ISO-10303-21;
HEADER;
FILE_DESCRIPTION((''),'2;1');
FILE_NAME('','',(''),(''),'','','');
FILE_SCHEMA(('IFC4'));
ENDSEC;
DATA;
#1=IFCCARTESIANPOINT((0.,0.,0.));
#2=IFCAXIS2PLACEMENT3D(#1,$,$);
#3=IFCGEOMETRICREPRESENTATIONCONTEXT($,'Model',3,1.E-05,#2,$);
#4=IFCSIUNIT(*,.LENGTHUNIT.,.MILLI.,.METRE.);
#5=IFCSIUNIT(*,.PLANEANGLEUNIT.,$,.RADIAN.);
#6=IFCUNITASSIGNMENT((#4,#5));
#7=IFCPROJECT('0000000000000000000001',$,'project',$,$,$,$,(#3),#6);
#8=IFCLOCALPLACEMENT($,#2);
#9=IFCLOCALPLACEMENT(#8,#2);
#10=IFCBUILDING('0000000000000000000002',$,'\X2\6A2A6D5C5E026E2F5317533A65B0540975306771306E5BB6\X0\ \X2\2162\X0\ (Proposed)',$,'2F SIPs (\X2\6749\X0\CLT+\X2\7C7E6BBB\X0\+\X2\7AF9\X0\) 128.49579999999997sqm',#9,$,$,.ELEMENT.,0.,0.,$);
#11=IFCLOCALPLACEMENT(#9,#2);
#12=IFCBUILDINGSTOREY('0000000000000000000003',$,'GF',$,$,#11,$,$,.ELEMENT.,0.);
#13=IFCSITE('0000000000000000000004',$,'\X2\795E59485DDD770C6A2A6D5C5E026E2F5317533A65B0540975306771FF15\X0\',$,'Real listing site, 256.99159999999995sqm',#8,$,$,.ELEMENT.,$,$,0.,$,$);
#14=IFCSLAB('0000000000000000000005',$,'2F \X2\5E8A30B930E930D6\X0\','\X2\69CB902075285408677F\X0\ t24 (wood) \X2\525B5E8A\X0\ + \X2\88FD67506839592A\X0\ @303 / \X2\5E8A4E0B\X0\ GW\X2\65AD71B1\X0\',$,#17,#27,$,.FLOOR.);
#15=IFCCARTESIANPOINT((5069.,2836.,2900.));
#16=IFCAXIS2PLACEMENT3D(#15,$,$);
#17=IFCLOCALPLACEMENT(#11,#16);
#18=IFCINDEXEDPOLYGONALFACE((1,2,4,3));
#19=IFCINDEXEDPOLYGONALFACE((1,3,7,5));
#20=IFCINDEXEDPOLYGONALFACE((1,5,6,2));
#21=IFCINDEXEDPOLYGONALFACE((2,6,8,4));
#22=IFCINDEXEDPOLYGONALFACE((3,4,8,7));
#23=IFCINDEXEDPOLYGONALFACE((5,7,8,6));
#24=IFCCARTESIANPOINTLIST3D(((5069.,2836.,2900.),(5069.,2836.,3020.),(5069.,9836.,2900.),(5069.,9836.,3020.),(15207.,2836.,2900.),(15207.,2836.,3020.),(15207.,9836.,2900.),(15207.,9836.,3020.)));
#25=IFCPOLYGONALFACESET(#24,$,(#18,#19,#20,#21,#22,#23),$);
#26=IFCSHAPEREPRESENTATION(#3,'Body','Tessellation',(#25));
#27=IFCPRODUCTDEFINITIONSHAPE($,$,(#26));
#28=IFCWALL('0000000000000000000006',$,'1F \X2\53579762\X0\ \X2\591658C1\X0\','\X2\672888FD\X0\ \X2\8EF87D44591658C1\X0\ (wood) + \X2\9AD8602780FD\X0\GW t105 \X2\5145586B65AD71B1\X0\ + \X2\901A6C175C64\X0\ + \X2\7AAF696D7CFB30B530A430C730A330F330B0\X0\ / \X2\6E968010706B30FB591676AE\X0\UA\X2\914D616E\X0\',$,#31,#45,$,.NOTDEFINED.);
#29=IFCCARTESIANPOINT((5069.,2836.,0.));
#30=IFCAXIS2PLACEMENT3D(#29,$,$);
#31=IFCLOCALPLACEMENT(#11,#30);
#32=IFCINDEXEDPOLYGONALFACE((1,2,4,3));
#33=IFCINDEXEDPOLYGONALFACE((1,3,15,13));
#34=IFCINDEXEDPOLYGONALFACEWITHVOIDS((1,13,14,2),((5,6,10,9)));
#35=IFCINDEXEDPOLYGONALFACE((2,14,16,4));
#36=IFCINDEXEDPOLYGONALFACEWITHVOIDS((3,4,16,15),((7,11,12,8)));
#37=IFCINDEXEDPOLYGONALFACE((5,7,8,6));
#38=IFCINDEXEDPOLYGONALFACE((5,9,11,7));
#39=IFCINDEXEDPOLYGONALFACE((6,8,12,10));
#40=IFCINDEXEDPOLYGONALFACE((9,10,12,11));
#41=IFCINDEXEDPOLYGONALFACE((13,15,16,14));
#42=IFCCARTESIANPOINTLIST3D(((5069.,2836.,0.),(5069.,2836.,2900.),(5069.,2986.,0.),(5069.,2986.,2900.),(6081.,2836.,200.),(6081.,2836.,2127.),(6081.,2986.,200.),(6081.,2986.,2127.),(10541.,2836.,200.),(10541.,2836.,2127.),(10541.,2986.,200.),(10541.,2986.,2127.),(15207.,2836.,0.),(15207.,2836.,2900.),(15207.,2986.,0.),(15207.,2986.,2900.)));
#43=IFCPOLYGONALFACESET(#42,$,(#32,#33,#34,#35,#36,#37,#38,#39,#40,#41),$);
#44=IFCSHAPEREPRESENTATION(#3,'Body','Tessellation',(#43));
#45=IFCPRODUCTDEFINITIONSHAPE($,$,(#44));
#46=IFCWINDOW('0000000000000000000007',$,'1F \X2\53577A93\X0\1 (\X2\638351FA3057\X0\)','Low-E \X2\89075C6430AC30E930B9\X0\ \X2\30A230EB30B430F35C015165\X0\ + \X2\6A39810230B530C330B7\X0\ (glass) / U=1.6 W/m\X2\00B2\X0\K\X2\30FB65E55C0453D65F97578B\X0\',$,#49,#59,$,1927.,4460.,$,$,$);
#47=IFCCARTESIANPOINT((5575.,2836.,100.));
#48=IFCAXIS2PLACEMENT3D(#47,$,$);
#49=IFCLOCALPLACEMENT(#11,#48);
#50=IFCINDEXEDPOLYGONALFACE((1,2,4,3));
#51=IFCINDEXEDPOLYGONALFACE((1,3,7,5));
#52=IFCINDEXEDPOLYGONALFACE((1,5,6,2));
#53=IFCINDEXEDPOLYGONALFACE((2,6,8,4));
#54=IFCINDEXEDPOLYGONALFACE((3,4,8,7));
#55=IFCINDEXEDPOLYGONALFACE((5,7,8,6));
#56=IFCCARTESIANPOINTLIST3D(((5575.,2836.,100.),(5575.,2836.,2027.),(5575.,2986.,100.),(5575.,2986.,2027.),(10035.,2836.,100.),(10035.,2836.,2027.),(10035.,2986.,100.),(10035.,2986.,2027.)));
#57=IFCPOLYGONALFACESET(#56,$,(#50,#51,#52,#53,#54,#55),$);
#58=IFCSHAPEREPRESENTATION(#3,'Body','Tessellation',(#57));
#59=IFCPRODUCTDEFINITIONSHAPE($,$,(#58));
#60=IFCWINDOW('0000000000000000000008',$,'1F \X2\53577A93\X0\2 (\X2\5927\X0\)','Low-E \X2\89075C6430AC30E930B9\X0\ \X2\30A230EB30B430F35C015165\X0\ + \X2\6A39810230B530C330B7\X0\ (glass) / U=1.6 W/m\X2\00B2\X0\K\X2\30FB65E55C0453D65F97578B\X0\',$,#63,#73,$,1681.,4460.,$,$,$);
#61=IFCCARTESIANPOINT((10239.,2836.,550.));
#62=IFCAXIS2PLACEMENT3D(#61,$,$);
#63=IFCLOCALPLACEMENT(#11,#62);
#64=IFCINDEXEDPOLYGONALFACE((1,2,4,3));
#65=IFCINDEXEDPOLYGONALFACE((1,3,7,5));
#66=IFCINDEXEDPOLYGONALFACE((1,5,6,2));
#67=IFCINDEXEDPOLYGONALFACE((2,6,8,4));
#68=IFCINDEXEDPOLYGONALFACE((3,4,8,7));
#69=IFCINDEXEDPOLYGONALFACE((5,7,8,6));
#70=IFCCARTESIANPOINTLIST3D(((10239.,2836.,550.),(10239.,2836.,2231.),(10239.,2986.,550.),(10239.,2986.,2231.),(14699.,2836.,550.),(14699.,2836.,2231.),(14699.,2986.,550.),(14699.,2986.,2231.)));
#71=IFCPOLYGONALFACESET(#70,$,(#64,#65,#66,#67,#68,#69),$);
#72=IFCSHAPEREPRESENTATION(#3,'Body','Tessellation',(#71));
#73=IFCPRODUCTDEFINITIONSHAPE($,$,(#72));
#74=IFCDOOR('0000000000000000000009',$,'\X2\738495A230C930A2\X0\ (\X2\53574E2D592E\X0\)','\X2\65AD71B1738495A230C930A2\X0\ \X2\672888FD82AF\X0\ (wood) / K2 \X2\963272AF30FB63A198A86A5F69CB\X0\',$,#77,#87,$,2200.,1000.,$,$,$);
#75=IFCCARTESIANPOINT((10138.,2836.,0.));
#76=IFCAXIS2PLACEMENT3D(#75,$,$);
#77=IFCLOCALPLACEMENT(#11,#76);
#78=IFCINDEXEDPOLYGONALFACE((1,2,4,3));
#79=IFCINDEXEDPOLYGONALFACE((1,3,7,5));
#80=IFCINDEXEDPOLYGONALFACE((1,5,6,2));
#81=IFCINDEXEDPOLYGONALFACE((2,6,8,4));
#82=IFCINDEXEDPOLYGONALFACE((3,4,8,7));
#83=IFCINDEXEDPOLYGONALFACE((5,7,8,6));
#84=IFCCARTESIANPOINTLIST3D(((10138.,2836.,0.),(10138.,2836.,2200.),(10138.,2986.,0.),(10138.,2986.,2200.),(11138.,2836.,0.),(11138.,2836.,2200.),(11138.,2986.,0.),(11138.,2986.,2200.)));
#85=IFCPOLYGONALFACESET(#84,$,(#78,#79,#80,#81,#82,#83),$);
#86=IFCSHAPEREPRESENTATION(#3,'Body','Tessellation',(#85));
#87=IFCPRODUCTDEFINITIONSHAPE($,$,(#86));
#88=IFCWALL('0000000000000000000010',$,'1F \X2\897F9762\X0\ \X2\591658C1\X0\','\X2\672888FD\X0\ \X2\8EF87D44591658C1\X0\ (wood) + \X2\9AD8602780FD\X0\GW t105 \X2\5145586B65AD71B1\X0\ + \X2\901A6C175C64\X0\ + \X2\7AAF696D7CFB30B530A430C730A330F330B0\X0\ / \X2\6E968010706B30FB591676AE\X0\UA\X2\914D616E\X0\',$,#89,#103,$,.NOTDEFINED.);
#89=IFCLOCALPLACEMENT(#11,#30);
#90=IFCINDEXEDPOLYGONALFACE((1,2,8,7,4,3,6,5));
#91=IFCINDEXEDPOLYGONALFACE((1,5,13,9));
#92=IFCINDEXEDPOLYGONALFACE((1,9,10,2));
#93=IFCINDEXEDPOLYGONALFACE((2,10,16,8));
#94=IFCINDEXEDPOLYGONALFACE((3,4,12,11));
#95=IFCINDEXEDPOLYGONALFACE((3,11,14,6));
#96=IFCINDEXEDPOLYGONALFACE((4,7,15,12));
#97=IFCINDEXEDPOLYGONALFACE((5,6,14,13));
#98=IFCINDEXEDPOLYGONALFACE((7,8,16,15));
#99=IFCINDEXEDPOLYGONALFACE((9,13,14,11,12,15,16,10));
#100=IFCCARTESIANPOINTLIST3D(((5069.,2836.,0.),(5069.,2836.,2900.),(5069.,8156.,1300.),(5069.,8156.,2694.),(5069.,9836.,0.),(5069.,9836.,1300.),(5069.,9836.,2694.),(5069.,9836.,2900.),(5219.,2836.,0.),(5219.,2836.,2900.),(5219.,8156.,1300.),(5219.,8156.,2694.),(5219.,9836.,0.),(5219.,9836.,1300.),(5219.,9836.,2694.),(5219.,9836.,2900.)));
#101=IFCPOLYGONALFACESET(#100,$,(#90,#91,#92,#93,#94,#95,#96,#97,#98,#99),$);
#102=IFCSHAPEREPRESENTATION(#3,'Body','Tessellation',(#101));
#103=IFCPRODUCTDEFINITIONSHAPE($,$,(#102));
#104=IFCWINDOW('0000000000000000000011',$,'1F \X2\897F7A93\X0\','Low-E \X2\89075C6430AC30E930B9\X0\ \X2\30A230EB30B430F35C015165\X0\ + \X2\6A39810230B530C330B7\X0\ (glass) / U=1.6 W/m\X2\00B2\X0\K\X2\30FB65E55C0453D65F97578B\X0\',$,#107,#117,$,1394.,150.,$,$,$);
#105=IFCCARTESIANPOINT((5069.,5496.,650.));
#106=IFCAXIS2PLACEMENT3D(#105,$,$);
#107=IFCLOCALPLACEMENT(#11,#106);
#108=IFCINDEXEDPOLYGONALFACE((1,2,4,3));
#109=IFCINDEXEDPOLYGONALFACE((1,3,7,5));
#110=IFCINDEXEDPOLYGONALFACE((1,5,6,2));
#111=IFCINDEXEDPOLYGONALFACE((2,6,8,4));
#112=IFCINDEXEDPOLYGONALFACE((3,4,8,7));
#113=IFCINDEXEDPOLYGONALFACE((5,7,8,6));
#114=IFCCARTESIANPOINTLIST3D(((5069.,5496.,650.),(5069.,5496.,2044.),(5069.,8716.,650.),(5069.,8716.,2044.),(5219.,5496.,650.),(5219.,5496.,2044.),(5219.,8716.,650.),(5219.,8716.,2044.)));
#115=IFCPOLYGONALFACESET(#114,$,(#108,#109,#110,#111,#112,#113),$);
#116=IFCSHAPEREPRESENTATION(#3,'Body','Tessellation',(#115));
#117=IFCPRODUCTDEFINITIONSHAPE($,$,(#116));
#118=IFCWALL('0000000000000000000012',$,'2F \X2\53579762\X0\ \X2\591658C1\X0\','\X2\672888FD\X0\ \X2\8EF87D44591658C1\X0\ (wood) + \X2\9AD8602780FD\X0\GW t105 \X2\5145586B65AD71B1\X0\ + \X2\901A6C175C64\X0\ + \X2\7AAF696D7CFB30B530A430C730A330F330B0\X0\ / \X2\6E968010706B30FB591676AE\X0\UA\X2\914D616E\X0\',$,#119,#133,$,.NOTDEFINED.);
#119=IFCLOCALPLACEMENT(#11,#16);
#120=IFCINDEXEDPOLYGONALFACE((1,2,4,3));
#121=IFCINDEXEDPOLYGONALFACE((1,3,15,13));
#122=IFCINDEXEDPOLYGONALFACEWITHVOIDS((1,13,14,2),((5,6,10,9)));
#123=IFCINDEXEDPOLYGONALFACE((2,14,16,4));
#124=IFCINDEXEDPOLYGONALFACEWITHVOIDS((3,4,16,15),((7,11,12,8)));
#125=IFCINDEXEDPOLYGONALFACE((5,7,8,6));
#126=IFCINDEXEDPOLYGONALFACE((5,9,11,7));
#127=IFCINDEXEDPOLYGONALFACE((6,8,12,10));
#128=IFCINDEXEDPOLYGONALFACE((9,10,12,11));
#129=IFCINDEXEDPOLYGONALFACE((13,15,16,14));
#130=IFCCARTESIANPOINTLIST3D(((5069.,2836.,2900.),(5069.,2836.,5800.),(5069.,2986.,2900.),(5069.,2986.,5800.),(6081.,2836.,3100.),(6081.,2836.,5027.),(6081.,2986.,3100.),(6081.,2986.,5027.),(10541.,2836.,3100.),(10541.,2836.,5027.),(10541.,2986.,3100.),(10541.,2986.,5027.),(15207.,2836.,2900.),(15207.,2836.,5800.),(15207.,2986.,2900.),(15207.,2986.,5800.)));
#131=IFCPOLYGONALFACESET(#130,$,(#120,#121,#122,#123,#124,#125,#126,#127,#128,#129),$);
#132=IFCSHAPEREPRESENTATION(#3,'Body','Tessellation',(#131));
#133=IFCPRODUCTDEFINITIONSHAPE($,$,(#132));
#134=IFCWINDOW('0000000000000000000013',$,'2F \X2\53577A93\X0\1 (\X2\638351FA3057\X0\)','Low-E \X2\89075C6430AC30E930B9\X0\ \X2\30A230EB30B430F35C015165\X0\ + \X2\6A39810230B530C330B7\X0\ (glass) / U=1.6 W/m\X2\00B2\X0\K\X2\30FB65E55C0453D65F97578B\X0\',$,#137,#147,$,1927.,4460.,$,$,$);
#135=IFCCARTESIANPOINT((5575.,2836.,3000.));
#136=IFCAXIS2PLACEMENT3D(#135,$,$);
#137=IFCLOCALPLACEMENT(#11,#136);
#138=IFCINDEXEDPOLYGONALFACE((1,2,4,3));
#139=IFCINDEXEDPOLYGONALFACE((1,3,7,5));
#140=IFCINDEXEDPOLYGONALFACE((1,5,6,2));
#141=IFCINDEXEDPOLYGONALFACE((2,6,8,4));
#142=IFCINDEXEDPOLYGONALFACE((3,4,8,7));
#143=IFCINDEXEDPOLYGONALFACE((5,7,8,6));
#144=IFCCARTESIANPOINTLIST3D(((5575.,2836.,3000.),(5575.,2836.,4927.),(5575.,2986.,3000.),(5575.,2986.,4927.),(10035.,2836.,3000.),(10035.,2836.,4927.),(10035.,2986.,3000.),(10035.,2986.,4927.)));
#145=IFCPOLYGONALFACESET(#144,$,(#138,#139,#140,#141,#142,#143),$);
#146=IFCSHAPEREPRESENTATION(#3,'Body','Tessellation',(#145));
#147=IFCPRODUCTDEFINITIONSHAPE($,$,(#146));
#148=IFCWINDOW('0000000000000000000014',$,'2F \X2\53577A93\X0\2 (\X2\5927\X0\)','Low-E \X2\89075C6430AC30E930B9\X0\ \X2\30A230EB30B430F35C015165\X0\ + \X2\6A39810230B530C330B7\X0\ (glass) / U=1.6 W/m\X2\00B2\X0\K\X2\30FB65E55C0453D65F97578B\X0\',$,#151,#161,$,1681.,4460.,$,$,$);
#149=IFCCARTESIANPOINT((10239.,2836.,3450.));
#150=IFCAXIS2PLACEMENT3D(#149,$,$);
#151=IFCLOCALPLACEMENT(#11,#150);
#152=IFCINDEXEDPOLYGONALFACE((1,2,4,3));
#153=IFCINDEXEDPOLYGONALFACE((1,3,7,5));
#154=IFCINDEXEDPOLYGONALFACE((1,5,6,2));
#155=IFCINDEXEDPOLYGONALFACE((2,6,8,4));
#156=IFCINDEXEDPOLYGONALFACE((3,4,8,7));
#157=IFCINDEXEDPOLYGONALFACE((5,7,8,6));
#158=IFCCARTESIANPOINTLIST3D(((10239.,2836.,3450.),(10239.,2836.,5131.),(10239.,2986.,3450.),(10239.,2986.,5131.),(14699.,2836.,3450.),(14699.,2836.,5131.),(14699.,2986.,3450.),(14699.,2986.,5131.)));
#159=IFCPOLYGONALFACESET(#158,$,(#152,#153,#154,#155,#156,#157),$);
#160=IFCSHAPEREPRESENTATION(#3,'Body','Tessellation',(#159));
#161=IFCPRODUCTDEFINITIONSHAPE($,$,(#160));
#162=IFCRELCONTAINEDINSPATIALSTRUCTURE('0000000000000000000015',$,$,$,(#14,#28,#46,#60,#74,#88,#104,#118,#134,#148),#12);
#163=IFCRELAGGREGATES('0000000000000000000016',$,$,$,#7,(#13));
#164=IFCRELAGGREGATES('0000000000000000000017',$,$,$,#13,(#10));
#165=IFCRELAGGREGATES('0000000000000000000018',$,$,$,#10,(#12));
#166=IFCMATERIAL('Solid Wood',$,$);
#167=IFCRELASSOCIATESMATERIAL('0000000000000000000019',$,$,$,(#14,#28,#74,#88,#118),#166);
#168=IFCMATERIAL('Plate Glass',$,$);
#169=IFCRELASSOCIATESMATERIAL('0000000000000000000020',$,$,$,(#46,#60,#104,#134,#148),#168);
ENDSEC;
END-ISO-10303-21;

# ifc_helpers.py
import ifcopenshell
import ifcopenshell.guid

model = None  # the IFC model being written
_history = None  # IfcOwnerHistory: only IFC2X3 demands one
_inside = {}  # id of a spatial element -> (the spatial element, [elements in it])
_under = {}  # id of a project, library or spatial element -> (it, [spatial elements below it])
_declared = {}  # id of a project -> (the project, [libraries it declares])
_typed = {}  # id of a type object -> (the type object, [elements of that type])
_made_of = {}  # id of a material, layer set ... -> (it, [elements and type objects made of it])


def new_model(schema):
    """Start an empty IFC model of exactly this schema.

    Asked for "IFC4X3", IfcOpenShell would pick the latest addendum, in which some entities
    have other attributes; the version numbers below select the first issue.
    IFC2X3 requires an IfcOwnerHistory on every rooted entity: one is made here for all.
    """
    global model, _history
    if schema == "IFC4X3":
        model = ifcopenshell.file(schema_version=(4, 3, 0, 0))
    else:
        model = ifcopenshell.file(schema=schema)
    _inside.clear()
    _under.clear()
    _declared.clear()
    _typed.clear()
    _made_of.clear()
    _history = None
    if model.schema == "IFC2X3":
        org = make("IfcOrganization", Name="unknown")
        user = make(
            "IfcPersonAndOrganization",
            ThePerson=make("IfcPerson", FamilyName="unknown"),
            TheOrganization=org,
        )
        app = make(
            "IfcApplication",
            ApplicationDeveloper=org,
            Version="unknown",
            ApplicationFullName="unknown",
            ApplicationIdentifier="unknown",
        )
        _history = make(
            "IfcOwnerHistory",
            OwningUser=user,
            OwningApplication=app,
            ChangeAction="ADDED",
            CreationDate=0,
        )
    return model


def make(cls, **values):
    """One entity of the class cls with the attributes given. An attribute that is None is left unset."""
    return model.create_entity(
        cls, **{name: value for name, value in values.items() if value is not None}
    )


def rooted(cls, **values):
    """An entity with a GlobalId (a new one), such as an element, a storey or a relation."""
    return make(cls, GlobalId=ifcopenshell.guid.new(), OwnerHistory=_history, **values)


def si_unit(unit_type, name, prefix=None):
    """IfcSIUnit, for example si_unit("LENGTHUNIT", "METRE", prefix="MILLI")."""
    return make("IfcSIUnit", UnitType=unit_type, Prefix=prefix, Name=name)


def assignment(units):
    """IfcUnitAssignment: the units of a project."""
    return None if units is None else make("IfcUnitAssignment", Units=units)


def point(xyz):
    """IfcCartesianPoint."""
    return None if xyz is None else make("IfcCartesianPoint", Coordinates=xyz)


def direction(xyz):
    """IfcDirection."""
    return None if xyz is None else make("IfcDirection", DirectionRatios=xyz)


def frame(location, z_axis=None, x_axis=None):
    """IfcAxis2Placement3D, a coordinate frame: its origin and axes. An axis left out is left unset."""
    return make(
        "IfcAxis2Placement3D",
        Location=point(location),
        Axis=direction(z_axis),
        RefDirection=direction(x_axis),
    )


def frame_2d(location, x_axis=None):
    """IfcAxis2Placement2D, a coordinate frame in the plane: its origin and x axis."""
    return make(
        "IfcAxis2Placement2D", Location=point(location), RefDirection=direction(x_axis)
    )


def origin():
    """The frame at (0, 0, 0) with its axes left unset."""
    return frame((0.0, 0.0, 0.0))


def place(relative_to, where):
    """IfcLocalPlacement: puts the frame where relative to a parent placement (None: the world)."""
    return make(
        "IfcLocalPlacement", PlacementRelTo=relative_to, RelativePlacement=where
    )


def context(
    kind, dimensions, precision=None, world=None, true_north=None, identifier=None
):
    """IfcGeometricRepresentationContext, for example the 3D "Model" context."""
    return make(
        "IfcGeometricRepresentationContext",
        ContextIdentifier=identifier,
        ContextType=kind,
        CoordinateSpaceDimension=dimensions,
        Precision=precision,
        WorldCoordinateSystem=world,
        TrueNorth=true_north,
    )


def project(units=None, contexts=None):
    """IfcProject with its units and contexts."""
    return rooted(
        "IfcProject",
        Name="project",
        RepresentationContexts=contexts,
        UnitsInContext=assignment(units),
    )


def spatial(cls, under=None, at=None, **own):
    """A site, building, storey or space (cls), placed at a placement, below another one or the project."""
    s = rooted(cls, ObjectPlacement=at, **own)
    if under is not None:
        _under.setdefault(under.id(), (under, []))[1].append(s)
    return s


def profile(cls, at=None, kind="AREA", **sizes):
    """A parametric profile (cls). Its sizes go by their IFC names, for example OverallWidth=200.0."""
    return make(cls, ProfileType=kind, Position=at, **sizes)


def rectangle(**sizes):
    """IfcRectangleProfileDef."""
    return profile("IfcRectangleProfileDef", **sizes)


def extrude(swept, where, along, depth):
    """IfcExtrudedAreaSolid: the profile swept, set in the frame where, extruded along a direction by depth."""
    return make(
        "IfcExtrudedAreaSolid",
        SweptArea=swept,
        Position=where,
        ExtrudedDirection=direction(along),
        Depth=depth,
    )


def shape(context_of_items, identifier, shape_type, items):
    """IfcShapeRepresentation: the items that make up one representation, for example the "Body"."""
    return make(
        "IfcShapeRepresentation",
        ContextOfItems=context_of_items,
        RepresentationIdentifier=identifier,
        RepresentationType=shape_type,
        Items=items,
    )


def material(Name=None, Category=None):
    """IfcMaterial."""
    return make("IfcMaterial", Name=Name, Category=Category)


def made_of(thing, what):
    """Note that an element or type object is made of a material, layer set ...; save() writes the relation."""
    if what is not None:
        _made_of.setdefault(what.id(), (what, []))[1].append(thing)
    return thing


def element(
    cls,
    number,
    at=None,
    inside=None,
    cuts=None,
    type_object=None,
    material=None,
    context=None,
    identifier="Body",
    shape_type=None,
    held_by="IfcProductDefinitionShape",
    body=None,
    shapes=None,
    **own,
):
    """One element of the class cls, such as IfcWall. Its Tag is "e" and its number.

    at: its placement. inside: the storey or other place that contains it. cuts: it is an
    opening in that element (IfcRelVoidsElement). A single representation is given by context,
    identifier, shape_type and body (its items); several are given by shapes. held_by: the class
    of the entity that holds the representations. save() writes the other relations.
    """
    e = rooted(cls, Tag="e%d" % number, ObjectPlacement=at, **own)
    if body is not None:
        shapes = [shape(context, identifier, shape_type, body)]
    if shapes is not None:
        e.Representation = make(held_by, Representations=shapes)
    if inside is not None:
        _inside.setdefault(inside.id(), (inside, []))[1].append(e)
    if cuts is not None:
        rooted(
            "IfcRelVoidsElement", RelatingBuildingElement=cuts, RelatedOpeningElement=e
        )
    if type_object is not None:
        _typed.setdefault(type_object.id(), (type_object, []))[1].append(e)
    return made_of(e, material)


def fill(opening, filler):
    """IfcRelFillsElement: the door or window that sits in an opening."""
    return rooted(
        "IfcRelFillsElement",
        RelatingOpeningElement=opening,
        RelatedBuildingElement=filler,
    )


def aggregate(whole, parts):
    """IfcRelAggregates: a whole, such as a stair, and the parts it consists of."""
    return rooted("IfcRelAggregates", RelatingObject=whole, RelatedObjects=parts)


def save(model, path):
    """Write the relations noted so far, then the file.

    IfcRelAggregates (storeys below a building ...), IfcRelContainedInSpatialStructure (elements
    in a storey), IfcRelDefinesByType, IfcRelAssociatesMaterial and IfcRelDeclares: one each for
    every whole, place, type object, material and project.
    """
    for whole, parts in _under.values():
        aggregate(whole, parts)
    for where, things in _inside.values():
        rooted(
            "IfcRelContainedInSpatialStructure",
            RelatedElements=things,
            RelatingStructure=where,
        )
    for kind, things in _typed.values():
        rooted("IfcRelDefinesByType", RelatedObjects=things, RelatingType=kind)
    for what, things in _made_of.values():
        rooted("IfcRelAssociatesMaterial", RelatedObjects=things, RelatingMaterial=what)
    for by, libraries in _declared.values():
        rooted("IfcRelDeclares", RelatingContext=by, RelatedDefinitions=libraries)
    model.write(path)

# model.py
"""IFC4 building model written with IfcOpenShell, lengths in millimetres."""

from ifc_helpers import new_model, si_unit, frame, frame_2d, origin, place, context, project, spatial, rectangle, extrude, material, element, fill, save


model = new_model("IFC4")

# Units and contexts
model_context = context("Model", 3, precision=1e-05, world=origin())
ifc_project = project(units=[si_unit("LENGTHUNIT", "METRE", prefix="MILLI"), si_unit("PLANEANGLEUNIT", "RADIAN")], contexts=[model_context])

# Site, building, storey
site_placement = place(None, origin())
site = spatial("IfcSite", under=ifc_project, at=site_placement, Name="神奈川県横浜市港北区新吉田東５", ObjectType="Real listing site, 256.99159999999995sqm", CompositionType="ELEMENT", RefElevation=0.0)
building_placement = place(site_placement, origin())
building = spatial("IfcBuilding", under=site, at=building_placement, Name="横浜市港北区新吉田東の家 Ⅲ (Proposed)", ObjectType="2F SIPs (杉CLT+籾殻+竹) 128.49579999999997sqm", CompositionType="ELEMENT", ElevationOfRefHeight=0.0, ElevationOfTerrain=0.0)
storey_placement = place(building_placement, origin())
storey = spatial("IfcBuildingStorey", under=building, at=storey_placement, Name="GF", CompositionType="ELEMENT", Elevation=0.0)

# Slab
ifc_material_1 = material(Name="Solid Wood")
slab_1_placement = place(storey_placement, frame((5069.0, 2836.0, 2900.0)))
element("IfcSlab", 1, at=slab_1_placement, inside=storey, material=ifc_material_1, Name="2F 床スラブ", Description="構造用合板 t24 (wood) 剛床 + 製材根太 @303 / 床下 GW断熱", PredefinedType="FLOOR", context=model_context, shape_type="SweptSolid", body=[
    extrude(rectangle(XDim=10138.0, YDim=7000.0, at=frame_2d((5069.0, 3500.0))), frame((5069.0, 2836.0, 2900.0)), (0.0, 0.0, 1.0), 120.0),
])

# Wall, openings, windows, door
wall_1_placement = place(storey_placement, frame((5069.0, 2836.0, 0.0)))
wall_1 = element("IfcWall", 2, at=wall_1_placement, inside=storey, material=ifc_material_1, Name="1F 南面 外壁", Description="木製 軸組外壁 (wood) + 高性能GW t105 充填断熱 + 通気層 + 窯業系サイディング / 準耐火・外皮UA配慮", PredefinedType="NOTDEFINED", context=model_context, shape_type="SweptSolid", body=[
    extrude(rectangle(XDim=10138.0, YDim=150.0, at=frame_2d((5069.0, 75.0))), frame((5069.0, 2836.0, 0.0)), (0.0, 0.0, 1.0), 2900.0),
])
opening_1_placement = place(storey_placement, frame((5575.0, 2836.0, 100.0)))
opening_1 = element("IfcOpeningElement", 3, at=opening_1_placement, cuts=wall_1, PredefinedType="NOTDEFINED", context=model_context, shape_type="SweptSolid", body=[
    extrude(rectangle(XDim=4460.0, YDim=150.0, at=frame_2d((2230.0, 75.0))), frame((5575.0, 2836.0, 100.0)), (0.0, 0.0, 1.0), 1927.0),
])
opening_2_placement = place(storey_placement, frame((10239.0, 2836.0, 550.0)))
opening_2 = element("IfcOpeningElement", 4, at=opening_2_placement, cuts=wall_1, PredefinedType="NOTDEFINED", context=model_context, shape_type="SweptSolid", body=[
    extrude(rectangle(XDim=4460.0, YDim=150.0, at=frame_2d((2230.0, 75.0))), frame((10239.0, 2836.0, 550.0)), (0.0, 0.0, 1.0), 1681.0),
])
opening_3_placement = place(storey_placement, frame((10138.0, 2836.0, 0.0)))
opening_3 = element("IfcOpeningElement", 5, at=opening_3_placement, cuts=wall_1, PredefinedType="NOTDEFINED", context=model_context, shape_type="SweptSolid", body=[
    extrude(rectangle(XDim=1000.0, YDim=150.0, at=frame_2d((500.0, 75.0))), frame((10138.0, 2836.0, 0.0)), (0.0, 0.0, 1.0), 2200.0),
])
ifc_material_2 = material(Name="Plate Glass")
window_1_placement = place(storey_placement, frame((5575.0, 2836.0, 100.0)))
window_1 = element("IfcWindow", 6, at=window_1_placement, inside=storey, material=ifc_material_2, Name="1F 南窓1 (掃出し)", Description="Low-E 複層ガラス アルゴン封入 + 樹脂サッシ (glass) / U=1.6 W/m²K・日射取得型", OverallHeight=1927.0, OverallWidth=4460.0, context=model_context, shape_type="SweptSolid", body=[
    extrude(rectangle(XDim=4460.0, YDim=150.0, at=frame_2d((2230.0, 75.0))), frame((5575.0, 2836.0, 100.0)), (0.0, 0.0, 1.0), 1927.0),
])
fill(opening_1, window_1)
window_2_placement = place(storey_placement, frame((10239.0, 2836.0, 550.0)))
window_2 = element("IfcWindow", 7, at=window_2_placement, inside=storey, material=ifc_material_2, Name="1F 南窓2 (大)", Description="Low-E 複層ガラス アルゴン封入 + 樹脂サッシ (glass) / U=1.6 W/m²K・日射取得型", OverallHeight=1681.0, OverallWidth=4460.0, context=model_context, shape_type="SweptSolid", body=[
    extrude(rectangle(XDim=4460.0, YDim=150.0, at=frame_2d((2230.0, 75.0))), frame((10239.0, 2836.0, 550.0)), (0.0, 0.0, 1.0), 1681.0),
])
fill(opening_2, window_2)
door_placement = place(storey_placement, frame((10138.0, 2836.0, 0.0)))
door = element("IfcDoor", 8, at=door_placement, inside=storey, material=ifc_material_1, Name="玄関ドア (南中央)", Description="断熱玄関ドア 木製芯 (wood) / K2 防犯・採風機構", OverallHeight=2200.0, OverallWidth=1000.0, context=model_context, shape_type="SweptSolid", body=[
    extrude(rectangle(XDim=1000.0, YDim=150.0, at=frame_2d((500.0, 75.0))), frame((10138.0, 2836.0, 0.0)), (0.0, 0.0, 1.0), 2200.0),
])
fill(opening_3, door)

# Wall, opening, window
wall_2_placement = place(storey_placement, frame((5069.0, 2836.0, 0.0)))
wall_2 = element("IfcWall", 9, at=wall_2_placement, inside=storey, material=ifc_material_1, Name="1F 西面 外壁", Description="木製 軸組外壁 (wood) + 高性能GW t105 充填断熱 + 通気層 + 窯業系サイディング / 準耐火・外皮UA配慮", PredefinedType="NOTDEFINED", context=model_context, shape_type="SweptSolid", body=[
    extrude(rectangle(XDim=150.0, YDim=7000.0, at=frame_2d((75.0, 3500.0))), frame((5069.0, 2836.0, 0.0)), (0.0, 0.0, 1.0), 2900.0),
])
opening_4_placement = place(storey_placement, frame((5069.0, 5496.0, 650.0)))
opening_4 = element("IfcOpeningElement", 10, at=opening_4_placement, cuts=wall_2, PredefinedType="NOTDEFINED", context=model_context, shape_type="SweptSolid", body=[
    extrude(rectangle(XDim=150.0, YDim=3220.0, at=frame_2d((75.0, 1610.0))), frame((5069.0, 5496.0, 650.0)), (0.0, 0.0, 1.0), 1394.0),
])
window_3_placement = place(storey_placement, frame((5069.0, 5496.0, 650.0)))
window_3 = element("IfcWindow", 11, at=window_3_placement, inside=storey, material=ifc_material_2, Name="1F 西窓", Description="Low-E 複層ガラス アルゴン封入 + 樹脂サッシ (glass) / U=1.6 W/m²K・日射取得型", OverallHeight=1394.0, OverallWidth=150.0, context=model_context, shape_type="SweptSolid", body=[
    extrude(rectangle(XDim=150.0, YDim=3220.0, at=frame_2d((75.0, 1610.0))), frame((5069.0, 5496.0, 650.0)), (0.0, 0.0, 1.0), 1394.0),
])
fill(opening_4, window_3)

# Wall, openings, windows
wall_3_placement = place(storey_placement, frame((5069.0, 2836.0, 2900.0)))
wall_3 = element("IfcWall", 12, at=wall_3_placement, inside=storey, material=ifc_material_1, Name="2F 南面 外壁", Description="木製 軸組外壁 (wood) + 高性能GW t105 充填断熱 + 通気層 + 窯業系サイディング / 準耐火・外皮UA配慮", PredefinedType="NOTDEFINED", context=model_context, shape_type="SweptSolid", body=[
    extrude(rectangle(XDim=10138.0, YDim=150.0, at=frame_2d((5069.0, 75.0))), frame((5069.0, 2836.0, 2900.0)), (0.0, 0.0, 1.0), 2900.0),
])
opening_5_placement = place(storey_placement, frame((5575.0, 2836.0, 3000.0)))
opening_5 = element("IfcOpeningElement", 13, at=opening_5_placement, cuts=wall_3, PredefinedType="NOTDEFINED", context=model_context, shape_type="SweptSolid", body=[
    extrude(rectangle(XDim=4460.0, YDim=150.0, at=frame_2d((2230.0, 75.0))), frame((5575.0, 2836.0, 3000.0)), (0.0, 0.0, 1.0), 1927.0),
])
opening_6_placement = place(storey_placement, frame((10239.0, 2836.0, 3450.0)))
opening_6 = element("IfcOpeningElement", 14, at=opening_6_placement, cuts=wall_3, PredefinedType="NOTDEFINED", context=model_context, shape_type="SweptSolid", body=[
    extrude(rectangle(XDim=4460.0, YDim=150.0, at=frame_2d((2230.0, 75.0))), frame((10239.0, 2836.0, 3450.0)), (0.0, 0.0, 1.0), 1681.0),
])
window_4_placement = place(storey_placement, frame((5575.0, 2836.0, 3000.0)))
window_4 = element("IfcWindow", 15, at=window_4_placement, inside=storey, material=ifc_material_2, Name="2F 南窓1 (掃出し)", Description="Low-E 複層ガラス アルゴン封入 + 樹脂サッシ (glass) / U=1.6 W/m²K・日射取得型", OverallHeight=1927.0, OverallWidth=4460.0, context=model_context, shape_type="SweptSolid", body=[
    extrude(rectangle(XDim=4460.0, YDim=150.0, at=frame_2d((2230.0, 75.0))), frame((5575.0, 2836.0, 3000.0)), (0.0, 0.0, 1.0), 1927.0),
])
fill(opening_5, window_4)
window_5_placement = place(storey_placement, frame((10239.0, 2836.0, 3450.0)))
window_5 = element("IfcWindow", 16, at=window_5_placement, inside=storey, material=ifc_material_2, Name="2F 南窓2 (大)", Description="Low-E 複層ガラス アルゴン封入 + 樹脂サッシ (glass) / U=1.6 W/m²K・日射取得型", OverallHeight=1681.0, OverallWidth=4460.0, context=model_context, shape_type="SweptSolid", body=[
    extrude(rectangle(XDim=4460.0, YDim=150.0, at=frame_2d((2230.0, 75.0))), frame((10239.0, 2836.0, 3450.0)), (0.0, 0.0, 1.0), 1681.0),
])
fill(opening_6, window_5)

save(model, "model.ifc")
